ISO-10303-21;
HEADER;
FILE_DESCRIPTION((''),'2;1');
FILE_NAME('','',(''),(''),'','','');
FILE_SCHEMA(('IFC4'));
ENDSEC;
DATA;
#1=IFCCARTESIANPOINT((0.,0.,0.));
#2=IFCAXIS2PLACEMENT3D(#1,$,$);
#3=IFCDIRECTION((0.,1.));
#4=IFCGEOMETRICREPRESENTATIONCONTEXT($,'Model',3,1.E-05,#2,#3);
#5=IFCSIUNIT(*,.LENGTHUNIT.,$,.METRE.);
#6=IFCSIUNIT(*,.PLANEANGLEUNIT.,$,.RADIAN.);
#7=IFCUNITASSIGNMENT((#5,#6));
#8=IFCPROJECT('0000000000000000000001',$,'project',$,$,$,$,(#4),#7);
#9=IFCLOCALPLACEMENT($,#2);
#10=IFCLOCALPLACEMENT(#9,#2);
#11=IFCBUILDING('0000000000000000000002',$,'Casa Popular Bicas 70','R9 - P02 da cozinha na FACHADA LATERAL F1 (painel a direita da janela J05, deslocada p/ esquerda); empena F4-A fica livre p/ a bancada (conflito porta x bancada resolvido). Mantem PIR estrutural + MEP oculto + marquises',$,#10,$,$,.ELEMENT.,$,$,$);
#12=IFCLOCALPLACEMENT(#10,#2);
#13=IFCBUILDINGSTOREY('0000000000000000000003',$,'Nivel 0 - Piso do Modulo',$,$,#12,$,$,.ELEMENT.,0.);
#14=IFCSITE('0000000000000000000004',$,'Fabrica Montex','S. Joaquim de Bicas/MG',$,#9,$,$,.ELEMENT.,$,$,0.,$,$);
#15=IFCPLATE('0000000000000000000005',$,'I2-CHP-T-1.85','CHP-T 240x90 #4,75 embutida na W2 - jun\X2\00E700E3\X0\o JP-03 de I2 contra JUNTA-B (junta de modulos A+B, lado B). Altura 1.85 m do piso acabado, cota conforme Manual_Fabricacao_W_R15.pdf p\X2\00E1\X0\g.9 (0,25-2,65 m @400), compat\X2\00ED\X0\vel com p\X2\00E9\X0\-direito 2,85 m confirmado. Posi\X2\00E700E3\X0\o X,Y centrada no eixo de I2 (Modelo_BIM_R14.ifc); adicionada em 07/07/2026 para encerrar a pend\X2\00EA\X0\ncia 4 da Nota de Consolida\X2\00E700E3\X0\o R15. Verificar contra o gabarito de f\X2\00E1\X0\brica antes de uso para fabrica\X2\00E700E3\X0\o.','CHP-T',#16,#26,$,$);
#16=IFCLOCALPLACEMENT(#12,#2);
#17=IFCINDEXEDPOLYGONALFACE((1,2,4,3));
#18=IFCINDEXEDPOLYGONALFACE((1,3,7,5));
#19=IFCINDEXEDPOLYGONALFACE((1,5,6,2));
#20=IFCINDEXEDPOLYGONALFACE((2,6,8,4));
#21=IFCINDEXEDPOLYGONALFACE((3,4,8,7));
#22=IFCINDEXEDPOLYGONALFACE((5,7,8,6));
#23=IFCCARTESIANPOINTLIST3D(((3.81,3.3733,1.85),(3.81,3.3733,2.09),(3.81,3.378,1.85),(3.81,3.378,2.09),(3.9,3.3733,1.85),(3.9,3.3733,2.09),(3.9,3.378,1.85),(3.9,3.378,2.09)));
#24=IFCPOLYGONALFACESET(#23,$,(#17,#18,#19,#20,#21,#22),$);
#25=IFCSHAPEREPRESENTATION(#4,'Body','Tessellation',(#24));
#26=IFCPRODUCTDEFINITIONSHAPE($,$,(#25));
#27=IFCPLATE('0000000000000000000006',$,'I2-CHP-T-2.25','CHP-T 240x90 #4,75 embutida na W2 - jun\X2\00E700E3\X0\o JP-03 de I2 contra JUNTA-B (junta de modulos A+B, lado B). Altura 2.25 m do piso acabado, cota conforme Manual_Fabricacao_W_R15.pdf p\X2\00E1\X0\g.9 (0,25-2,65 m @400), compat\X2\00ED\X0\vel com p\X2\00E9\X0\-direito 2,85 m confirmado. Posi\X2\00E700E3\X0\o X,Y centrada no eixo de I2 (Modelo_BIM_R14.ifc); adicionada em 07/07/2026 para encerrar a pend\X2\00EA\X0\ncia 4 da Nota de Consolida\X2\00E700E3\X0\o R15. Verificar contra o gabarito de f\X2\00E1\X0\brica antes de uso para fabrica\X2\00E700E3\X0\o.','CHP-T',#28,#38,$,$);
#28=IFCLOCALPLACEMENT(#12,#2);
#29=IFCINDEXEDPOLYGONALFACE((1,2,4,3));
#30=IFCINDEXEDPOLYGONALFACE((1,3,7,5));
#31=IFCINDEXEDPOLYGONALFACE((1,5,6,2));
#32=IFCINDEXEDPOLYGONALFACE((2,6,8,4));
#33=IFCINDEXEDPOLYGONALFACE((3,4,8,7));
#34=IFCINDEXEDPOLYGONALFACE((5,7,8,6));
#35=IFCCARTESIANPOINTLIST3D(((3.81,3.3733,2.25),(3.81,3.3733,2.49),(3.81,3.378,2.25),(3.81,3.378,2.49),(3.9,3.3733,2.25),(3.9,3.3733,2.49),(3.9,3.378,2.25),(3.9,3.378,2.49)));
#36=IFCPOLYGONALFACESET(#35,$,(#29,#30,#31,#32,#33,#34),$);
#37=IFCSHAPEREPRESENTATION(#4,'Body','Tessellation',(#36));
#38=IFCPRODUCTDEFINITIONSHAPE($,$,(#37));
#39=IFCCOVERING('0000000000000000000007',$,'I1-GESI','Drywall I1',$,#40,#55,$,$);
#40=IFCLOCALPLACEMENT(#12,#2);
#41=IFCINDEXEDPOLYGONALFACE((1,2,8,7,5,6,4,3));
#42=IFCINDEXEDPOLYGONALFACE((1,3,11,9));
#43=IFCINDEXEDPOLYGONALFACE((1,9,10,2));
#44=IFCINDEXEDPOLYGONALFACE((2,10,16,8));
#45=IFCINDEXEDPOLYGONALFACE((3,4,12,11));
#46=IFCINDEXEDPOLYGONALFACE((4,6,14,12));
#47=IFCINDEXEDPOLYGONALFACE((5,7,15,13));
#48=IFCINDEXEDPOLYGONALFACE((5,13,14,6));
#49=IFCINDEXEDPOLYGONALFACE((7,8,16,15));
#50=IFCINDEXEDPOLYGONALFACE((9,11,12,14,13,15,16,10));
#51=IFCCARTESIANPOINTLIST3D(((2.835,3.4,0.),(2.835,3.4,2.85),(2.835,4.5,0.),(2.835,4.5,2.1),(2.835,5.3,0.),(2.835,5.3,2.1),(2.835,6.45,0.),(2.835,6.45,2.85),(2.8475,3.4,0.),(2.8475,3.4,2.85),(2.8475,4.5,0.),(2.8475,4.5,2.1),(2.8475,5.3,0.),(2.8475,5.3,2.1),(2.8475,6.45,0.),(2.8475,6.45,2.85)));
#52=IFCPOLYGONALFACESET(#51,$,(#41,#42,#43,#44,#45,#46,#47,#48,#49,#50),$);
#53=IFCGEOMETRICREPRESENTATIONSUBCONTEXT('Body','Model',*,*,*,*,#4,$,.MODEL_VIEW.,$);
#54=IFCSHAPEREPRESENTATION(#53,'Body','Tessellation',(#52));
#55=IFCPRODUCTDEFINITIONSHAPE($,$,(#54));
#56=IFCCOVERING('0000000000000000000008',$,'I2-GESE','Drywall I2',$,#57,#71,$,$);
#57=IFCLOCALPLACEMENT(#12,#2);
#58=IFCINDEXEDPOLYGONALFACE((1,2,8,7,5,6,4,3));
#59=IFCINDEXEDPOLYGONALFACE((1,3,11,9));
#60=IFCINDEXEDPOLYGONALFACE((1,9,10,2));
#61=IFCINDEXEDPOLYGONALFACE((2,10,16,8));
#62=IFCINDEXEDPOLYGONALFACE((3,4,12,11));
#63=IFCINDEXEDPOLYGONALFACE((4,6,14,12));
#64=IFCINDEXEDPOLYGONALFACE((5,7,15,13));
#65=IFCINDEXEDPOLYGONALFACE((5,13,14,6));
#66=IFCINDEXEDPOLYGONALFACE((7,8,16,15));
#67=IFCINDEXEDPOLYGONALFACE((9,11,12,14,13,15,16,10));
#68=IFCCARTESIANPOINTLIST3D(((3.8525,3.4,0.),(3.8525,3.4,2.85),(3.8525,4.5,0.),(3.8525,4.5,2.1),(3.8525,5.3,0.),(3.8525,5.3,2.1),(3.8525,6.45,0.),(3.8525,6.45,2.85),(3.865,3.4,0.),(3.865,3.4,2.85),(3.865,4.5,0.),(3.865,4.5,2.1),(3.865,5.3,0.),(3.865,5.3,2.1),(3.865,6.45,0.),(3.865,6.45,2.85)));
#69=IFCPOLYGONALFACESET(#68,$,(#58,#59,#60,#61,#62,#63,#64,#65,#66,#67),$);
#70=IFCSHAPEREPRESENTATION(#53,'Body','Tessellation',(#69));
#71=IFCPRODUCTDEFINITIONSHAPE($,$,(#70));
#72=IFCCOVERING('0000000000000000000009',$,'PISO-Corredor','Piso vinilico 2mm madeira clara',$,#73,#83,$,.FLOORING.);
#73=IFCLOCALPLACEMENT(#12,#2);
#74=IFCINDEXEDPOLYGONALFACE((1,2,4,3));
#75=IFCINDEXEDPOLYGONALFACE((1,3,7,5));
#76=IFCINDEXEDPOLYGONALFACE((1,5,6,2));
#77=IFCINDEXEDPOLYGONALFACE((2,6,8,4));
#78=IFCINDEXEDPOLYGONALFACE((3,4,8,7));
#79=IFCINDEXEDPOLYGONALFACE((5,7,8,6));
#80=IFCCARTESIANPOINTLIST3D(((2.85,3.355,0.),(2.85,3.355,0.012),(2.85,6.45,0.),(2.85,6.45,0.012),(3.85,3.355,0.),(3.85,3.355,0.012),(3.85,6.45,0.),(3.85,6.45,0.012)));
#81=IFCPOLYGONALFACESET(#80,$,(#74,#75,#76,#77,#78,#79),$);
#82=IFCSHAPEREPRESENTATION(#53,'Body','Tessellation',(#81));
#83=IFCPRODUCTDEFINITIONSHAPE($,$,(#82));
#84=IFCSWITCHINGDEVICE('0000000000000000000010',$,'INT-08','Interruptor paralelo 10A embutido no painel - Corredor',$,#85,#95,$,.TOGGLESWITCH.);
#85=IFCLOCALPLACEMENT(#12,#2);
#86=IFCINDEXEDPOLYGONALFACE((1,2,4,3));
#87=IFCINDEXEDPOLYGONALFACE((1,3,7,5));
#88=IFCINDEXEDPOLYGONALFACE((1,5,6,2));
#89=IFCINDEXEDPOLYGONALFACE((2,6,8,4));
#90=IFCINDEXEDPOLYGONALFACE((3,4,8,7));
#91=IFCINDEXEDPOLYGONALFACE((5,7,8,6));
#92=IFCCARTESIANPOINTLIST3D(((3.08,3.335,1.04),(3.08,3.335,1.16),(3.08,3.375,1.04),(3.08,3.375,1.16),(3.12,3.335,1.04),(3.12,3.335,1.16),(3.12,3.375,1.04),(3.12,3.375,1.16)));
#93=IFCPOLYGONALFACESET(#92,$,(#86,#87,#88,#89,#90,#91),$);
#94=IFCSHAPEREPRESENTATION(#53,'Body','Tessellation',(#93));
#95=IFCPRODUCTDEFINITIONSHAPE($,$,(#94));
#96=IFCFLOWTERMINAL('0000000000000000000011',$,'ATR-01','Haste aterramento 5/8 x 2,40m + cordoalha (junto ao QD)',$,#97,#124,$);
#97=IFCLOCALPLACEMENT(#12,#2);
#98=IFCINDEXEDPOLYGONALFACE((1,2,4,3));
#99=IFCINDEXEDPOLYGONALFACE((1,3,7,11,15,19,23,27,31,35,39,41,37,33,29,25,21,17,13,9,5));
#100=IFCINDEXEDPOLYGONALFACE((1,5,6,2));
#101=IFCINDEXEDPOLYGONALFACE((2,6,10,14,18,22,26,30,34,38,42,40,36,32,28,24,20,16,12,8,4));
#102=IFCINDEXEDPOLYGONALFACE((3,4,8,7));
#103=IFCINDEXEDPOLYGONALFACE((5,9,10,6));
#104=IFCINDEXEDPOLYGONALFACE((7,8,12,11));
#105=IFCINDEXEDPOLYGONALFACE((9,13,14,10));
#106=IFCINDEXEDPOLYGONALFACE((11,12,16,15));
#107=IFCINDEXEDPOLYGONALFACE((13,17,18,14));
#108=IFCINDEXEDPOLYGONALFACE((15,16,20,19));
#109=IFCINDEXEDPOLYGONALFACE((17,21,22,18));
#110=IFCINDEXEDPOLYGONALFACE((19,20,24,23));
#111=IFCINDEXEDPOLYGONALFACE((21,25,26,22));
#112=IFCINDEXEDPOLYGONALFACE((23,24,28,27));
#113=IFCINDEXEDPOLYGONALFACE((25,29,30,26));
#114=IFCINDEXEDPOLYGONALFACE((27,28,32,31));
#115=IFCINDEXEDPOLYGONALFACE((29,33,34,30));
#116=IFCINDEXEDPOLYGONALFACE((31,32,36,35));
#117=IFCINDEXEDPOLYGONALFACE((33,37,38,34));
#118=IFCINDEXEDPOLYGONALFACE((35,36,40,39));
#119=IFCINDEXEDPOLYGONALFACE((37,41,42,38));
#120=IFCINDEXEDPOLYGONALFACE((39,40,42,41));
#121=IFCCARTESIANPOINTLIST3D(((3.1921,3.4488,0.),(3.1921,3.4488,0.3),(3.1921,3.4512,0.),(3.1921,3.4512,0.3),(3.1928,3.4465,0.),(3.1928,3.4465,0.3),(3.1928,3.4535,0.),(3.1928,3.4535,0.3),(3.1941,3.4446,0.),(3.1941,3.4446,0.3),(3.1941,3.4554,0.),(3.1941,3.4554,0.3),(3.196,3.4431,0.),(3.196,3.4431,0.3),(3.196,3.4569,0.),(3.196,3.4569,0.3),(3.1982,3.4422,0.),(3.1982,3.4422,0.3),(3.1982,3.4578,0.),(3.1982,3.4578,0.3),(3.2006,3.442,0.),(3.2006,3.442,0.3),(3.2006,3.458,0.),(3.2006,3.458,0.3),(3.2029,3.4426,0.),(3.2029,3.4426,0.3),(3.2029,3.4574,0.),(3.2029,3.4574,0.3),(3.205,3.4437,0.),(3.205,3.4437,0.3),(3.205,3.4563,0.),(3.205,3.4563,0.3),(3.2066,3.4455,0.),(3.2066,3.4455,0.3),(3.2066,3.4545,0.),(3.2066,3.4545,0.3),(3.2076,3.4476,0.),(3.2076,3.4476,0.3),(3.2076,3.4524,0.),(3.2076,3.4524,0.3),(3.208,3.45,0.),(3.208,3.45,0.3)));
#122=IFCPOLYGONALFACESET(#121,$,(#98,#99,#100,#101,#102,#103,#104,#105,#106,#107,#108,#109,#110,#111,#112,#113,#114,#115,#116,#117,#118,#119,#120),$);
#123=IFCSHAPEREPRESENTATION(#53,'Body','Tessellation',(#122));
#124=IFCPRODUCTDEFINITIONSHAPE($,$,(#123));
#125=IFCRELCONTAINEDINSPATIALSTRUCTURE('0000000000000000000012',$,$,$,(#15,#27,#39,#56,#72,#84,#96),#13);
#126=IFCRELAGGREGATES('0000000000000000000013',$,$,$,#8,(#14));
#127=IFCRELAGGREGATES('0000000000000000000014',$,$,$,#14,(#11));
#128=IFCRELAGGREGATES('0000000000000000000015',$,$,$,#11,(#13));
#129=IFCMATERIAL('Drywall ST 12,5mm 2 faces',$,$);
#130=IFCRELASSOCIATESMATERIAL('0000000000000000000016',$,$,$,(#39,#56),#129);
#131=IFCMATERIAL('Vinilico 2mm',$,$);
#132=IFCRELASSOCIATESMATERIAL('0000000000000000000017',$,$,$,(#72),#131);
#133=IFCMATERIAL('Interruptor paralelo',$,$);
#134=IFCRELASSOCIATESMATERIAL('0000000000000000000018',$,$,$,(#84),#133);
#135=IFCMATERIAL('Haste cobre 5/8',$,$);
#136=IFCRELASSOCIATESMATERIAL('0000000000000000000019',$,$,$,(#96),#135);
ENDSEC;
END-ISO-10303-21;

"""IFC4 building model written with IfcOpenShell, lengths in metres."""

from ifc_helpers import new_model, si_unit, direction, frame, frame_2d, origin, origin_with_axes, origin_2d, place, context, subcontext, project, spatial, rectangle, circle, extrude, material, element, save


model = new_model("IFC4")

# Units and contexts
model_context = context("Model", 3, precision=1e-05, world=origin(), true_north=direction((0.0, 1.0)))
body_context = subcontext(model_context, "Body", "Model", "MODEL_VIEW")
ifc_project = project(units=[si_unit("LENGTHUNIT", "METRE"), si_unit("PLANEANGLEUNIT", "RADIAN")], contexts=[model_context])

# Site, building, storey
site_placement = place(None, origin())
site = spatial("IfcSite", under=ifc_project, at=site_placement, Name="Fabrica Montex", Description="S. Joaquim de Bicas/MG", CompositionType="ELEMENT", RefElevation=0.0)
building_placement = place(site_placement, origin())
building = spatial("IfcBuilding", under=site, at=building_placement, Name="Casa Popular Bicas 70", Description="R9 - P02 da cozinha na FACHADA LATERAL F1 (painel a direita da janela J05, deslocada p/ esquerda); empena F4-A fica livre p/ a bancada (conflito porta x bancada resolvido). Mantem PIR estrutural + MEP oculto + marquises", CompositionType="ELEMENT")
storey_placement = place(building_placement, origin())
storey = spatial("IfcBuildingStorey", under=building, at=storey_placement, Name="Nivel 0 - Piso do Modulo", CompositionType="ELEMENT", Elevation=0.0)

# Plates
for number, where, z_axis, x_axis, name, description in (
    (1, (3.855, 3.3756, 1.85), (0.0, 0.0, 1.0), (1.0, 0.0, 0.0), "I2-CHP-T-1.85", "CHP-T 240x90 #4,75 embutida na W2 - junção JP-03 de I2 contra JUNTA-B (junta de modulos A+B, lado B). Altura 1.85 m do piso acabado, cota conforme Manual_Fabricacao_W_R15.pdf pág.9 (0,25-2,65 m @400), compatível com pé-direito 2,85 m confirmado. Posição X,Y centrada no eixo de I2 (Modelo_BIM_R14.ifc); adicionada em 07/07/2026 para encerrar a pendência 4 da Nota de Consolidação R15. Verificar contra o gabarito de fábrica antes de uso para fabricação."),
    (2, (3.855, 3.3756, 2.25), (0.0, 0.0, 1.0), (1.0, 0.0, 0.0), "I2-CHP-T-2.25", "CHP-T 240x90 #4,75 embutida na W2 - junção JP-03 de I2 contra JUNTA-B (junta de modulos A+B, lado B). Altura 2.25 m do piso acabado, cota conforme Manual_Fabricacao_W_R15.pdf pág.9 (0,25-2,65 m @400), compatível com pé-direito 2,85 m confirmado. Posição X,Y centrada no eixo de I2 (Modelo_BIM_R14.ifc); adicionada em 07/07/2026 para encerrar a pendência 4 da Nota de Consolidação R15. Verificar contra o gabarito de fábrica antes de uso para fabricação."),
):
    element("IfcPlate", number, at=place(storey_placement, frame(where, z_axis=z_axis, x_axis=x_axis)), inside=storey, Name=name, Description=description, ObjectType="CHP-T", context=model_context, shape_type="SweptSolid", body=[
        extrude(rectangle(XDim=0.09, YDim=0.0047, at=origin_2d()), origin_with_axes(), (0.0, 0.0, 1.0), 0.24),
    ])

# Coverings, openings
ifc_material_1 = material(Name="Drywall ST 12,5mm 2 faces")
covering_1_placement = place(storey_placement, frame((2.8412, 3.4, 0.0), x_axis=(0.0, 1.0, 0.0)))
covering_1 = element("IfcCovering", 3, at=covering_1_placement, inside=storey, material=ifc_material_1, Name="I1-GESI", Description="Drywall I1", context=body_context, shape_type="SweptSolid", body=[
    extrude(rectangle(XDim=3.05, YDim=0.0125, at=frame_2d((1.525, 0.0))), origin(), (0.0, 0.0, 1.0), 2.85),
])
opening_1_placement = place(storey_placement, frame((2.8412, 4.9, 0.0)))
element("IfcOpeningElement", 4, at=opening_1_placement, cuts=covering_1, PredefinedType="OPENING", context=body_context, shape_type="SweptSolid", body=[
    extrude(rectangle(XDim=0.0425, YDim=0.8, at=origin_2d()), origin(), (0.0, 0.0, 1.0), 2.1),
])
covering_2_placement = place(storey_placement, frame((3.8588, 3.4, 0.0), x_axis=(0.0, 1.0, 0.0)))
covering_2 = element("IfcCovering", 5, at=covering_2_placement, inside=storey, material=ifc_material_1, Name="I2-GESE", Description="Drywall I2", context=body_context, shape_type="SweptSolid", body=[
    extrude(rectangle(XDim=3.05, YDim=0.0125, at=frame_2d((1.525, 0.0))), origin(), (0.0, 0.0, 1.0), 2.85),
])
opening_2_placement = place(storey_placement, frame((3.8588, 4.9, 0.0)))
element("IfcOpeningElement", 6, at=opening_2_placement, cuts=covering_2, PredefinedType="OPENING", context=body_context, shape_type="SweptSolid", body=[
    extrude(rectangle(XDim=0.0425, YDim=0.8, at=origin_2d()), origin(), (0.0, 0.0, 1.0), 2.1),
])

# Covering
ifc_material_2 = material(Name="Vinilico 2mm")
covering_3_placement = place(storey_placement, frame((2.85, 3.355, 0.0)))
element("IfcCovering", 7, at=covering_3_placement, inside=storey, material=ifc_material_2, Name="PISO-Corredor", Description="Piso vinilico 2mm madeira clara", PredefinedType="FLOORING", context=body_context, shape_type="SweptSolid", body=[
    extrude(rectangle(XDim=1.0, YDim=3.095, at=frame_2d((0.5, 1.5475))), origin(), (0.0, 0.0, 1.0), 0.012),
])

# Switching device
ifc_material_3 = material(Name="Interruptor paralelo")
switching_device_placement = place(storey_placement, frame((3.08, 3.335, 1.04)))
element("IfcSwitchingDevice", 8, at=switching_device_placement, inside=storey, material=ifc_material_3, Name="INT-08", Description="Interruptor paralelo 10A embutido no painel - Corredor", PredefinedType="TOGGLESWITCH", context=body_context, shape_type="SweptSolid", body=[
    extrude(rectangle(XDim=0.04, YDim=0.04, at=frame_2d((0.02, 0.02))), origin(), (0.0, 0.0, 1.0), 0.12),
])

# Flow terminal
ifc_material_4 = material(Name="Haste cobre 5/8")
flow_terminal_placement = place(storey_placement, frame((3.2, 3.45, 0.0)))
element("IfcFlowTerminal", 9, at=flow_terminal_placement, inside=storey, material=ifc_material_4, Name="ATR-01", Description="Haste aterramento 5/8 x 2,40m + cordoalha (junto ao QD)", context=body_context, shape_type="SweptSolid", body=[
    extrude(circle(Radius=0.008, at=origin_2d()), origin(), (0.0, 0.0, 1.0), 0.3),
])

save(model, "model.ifc")
